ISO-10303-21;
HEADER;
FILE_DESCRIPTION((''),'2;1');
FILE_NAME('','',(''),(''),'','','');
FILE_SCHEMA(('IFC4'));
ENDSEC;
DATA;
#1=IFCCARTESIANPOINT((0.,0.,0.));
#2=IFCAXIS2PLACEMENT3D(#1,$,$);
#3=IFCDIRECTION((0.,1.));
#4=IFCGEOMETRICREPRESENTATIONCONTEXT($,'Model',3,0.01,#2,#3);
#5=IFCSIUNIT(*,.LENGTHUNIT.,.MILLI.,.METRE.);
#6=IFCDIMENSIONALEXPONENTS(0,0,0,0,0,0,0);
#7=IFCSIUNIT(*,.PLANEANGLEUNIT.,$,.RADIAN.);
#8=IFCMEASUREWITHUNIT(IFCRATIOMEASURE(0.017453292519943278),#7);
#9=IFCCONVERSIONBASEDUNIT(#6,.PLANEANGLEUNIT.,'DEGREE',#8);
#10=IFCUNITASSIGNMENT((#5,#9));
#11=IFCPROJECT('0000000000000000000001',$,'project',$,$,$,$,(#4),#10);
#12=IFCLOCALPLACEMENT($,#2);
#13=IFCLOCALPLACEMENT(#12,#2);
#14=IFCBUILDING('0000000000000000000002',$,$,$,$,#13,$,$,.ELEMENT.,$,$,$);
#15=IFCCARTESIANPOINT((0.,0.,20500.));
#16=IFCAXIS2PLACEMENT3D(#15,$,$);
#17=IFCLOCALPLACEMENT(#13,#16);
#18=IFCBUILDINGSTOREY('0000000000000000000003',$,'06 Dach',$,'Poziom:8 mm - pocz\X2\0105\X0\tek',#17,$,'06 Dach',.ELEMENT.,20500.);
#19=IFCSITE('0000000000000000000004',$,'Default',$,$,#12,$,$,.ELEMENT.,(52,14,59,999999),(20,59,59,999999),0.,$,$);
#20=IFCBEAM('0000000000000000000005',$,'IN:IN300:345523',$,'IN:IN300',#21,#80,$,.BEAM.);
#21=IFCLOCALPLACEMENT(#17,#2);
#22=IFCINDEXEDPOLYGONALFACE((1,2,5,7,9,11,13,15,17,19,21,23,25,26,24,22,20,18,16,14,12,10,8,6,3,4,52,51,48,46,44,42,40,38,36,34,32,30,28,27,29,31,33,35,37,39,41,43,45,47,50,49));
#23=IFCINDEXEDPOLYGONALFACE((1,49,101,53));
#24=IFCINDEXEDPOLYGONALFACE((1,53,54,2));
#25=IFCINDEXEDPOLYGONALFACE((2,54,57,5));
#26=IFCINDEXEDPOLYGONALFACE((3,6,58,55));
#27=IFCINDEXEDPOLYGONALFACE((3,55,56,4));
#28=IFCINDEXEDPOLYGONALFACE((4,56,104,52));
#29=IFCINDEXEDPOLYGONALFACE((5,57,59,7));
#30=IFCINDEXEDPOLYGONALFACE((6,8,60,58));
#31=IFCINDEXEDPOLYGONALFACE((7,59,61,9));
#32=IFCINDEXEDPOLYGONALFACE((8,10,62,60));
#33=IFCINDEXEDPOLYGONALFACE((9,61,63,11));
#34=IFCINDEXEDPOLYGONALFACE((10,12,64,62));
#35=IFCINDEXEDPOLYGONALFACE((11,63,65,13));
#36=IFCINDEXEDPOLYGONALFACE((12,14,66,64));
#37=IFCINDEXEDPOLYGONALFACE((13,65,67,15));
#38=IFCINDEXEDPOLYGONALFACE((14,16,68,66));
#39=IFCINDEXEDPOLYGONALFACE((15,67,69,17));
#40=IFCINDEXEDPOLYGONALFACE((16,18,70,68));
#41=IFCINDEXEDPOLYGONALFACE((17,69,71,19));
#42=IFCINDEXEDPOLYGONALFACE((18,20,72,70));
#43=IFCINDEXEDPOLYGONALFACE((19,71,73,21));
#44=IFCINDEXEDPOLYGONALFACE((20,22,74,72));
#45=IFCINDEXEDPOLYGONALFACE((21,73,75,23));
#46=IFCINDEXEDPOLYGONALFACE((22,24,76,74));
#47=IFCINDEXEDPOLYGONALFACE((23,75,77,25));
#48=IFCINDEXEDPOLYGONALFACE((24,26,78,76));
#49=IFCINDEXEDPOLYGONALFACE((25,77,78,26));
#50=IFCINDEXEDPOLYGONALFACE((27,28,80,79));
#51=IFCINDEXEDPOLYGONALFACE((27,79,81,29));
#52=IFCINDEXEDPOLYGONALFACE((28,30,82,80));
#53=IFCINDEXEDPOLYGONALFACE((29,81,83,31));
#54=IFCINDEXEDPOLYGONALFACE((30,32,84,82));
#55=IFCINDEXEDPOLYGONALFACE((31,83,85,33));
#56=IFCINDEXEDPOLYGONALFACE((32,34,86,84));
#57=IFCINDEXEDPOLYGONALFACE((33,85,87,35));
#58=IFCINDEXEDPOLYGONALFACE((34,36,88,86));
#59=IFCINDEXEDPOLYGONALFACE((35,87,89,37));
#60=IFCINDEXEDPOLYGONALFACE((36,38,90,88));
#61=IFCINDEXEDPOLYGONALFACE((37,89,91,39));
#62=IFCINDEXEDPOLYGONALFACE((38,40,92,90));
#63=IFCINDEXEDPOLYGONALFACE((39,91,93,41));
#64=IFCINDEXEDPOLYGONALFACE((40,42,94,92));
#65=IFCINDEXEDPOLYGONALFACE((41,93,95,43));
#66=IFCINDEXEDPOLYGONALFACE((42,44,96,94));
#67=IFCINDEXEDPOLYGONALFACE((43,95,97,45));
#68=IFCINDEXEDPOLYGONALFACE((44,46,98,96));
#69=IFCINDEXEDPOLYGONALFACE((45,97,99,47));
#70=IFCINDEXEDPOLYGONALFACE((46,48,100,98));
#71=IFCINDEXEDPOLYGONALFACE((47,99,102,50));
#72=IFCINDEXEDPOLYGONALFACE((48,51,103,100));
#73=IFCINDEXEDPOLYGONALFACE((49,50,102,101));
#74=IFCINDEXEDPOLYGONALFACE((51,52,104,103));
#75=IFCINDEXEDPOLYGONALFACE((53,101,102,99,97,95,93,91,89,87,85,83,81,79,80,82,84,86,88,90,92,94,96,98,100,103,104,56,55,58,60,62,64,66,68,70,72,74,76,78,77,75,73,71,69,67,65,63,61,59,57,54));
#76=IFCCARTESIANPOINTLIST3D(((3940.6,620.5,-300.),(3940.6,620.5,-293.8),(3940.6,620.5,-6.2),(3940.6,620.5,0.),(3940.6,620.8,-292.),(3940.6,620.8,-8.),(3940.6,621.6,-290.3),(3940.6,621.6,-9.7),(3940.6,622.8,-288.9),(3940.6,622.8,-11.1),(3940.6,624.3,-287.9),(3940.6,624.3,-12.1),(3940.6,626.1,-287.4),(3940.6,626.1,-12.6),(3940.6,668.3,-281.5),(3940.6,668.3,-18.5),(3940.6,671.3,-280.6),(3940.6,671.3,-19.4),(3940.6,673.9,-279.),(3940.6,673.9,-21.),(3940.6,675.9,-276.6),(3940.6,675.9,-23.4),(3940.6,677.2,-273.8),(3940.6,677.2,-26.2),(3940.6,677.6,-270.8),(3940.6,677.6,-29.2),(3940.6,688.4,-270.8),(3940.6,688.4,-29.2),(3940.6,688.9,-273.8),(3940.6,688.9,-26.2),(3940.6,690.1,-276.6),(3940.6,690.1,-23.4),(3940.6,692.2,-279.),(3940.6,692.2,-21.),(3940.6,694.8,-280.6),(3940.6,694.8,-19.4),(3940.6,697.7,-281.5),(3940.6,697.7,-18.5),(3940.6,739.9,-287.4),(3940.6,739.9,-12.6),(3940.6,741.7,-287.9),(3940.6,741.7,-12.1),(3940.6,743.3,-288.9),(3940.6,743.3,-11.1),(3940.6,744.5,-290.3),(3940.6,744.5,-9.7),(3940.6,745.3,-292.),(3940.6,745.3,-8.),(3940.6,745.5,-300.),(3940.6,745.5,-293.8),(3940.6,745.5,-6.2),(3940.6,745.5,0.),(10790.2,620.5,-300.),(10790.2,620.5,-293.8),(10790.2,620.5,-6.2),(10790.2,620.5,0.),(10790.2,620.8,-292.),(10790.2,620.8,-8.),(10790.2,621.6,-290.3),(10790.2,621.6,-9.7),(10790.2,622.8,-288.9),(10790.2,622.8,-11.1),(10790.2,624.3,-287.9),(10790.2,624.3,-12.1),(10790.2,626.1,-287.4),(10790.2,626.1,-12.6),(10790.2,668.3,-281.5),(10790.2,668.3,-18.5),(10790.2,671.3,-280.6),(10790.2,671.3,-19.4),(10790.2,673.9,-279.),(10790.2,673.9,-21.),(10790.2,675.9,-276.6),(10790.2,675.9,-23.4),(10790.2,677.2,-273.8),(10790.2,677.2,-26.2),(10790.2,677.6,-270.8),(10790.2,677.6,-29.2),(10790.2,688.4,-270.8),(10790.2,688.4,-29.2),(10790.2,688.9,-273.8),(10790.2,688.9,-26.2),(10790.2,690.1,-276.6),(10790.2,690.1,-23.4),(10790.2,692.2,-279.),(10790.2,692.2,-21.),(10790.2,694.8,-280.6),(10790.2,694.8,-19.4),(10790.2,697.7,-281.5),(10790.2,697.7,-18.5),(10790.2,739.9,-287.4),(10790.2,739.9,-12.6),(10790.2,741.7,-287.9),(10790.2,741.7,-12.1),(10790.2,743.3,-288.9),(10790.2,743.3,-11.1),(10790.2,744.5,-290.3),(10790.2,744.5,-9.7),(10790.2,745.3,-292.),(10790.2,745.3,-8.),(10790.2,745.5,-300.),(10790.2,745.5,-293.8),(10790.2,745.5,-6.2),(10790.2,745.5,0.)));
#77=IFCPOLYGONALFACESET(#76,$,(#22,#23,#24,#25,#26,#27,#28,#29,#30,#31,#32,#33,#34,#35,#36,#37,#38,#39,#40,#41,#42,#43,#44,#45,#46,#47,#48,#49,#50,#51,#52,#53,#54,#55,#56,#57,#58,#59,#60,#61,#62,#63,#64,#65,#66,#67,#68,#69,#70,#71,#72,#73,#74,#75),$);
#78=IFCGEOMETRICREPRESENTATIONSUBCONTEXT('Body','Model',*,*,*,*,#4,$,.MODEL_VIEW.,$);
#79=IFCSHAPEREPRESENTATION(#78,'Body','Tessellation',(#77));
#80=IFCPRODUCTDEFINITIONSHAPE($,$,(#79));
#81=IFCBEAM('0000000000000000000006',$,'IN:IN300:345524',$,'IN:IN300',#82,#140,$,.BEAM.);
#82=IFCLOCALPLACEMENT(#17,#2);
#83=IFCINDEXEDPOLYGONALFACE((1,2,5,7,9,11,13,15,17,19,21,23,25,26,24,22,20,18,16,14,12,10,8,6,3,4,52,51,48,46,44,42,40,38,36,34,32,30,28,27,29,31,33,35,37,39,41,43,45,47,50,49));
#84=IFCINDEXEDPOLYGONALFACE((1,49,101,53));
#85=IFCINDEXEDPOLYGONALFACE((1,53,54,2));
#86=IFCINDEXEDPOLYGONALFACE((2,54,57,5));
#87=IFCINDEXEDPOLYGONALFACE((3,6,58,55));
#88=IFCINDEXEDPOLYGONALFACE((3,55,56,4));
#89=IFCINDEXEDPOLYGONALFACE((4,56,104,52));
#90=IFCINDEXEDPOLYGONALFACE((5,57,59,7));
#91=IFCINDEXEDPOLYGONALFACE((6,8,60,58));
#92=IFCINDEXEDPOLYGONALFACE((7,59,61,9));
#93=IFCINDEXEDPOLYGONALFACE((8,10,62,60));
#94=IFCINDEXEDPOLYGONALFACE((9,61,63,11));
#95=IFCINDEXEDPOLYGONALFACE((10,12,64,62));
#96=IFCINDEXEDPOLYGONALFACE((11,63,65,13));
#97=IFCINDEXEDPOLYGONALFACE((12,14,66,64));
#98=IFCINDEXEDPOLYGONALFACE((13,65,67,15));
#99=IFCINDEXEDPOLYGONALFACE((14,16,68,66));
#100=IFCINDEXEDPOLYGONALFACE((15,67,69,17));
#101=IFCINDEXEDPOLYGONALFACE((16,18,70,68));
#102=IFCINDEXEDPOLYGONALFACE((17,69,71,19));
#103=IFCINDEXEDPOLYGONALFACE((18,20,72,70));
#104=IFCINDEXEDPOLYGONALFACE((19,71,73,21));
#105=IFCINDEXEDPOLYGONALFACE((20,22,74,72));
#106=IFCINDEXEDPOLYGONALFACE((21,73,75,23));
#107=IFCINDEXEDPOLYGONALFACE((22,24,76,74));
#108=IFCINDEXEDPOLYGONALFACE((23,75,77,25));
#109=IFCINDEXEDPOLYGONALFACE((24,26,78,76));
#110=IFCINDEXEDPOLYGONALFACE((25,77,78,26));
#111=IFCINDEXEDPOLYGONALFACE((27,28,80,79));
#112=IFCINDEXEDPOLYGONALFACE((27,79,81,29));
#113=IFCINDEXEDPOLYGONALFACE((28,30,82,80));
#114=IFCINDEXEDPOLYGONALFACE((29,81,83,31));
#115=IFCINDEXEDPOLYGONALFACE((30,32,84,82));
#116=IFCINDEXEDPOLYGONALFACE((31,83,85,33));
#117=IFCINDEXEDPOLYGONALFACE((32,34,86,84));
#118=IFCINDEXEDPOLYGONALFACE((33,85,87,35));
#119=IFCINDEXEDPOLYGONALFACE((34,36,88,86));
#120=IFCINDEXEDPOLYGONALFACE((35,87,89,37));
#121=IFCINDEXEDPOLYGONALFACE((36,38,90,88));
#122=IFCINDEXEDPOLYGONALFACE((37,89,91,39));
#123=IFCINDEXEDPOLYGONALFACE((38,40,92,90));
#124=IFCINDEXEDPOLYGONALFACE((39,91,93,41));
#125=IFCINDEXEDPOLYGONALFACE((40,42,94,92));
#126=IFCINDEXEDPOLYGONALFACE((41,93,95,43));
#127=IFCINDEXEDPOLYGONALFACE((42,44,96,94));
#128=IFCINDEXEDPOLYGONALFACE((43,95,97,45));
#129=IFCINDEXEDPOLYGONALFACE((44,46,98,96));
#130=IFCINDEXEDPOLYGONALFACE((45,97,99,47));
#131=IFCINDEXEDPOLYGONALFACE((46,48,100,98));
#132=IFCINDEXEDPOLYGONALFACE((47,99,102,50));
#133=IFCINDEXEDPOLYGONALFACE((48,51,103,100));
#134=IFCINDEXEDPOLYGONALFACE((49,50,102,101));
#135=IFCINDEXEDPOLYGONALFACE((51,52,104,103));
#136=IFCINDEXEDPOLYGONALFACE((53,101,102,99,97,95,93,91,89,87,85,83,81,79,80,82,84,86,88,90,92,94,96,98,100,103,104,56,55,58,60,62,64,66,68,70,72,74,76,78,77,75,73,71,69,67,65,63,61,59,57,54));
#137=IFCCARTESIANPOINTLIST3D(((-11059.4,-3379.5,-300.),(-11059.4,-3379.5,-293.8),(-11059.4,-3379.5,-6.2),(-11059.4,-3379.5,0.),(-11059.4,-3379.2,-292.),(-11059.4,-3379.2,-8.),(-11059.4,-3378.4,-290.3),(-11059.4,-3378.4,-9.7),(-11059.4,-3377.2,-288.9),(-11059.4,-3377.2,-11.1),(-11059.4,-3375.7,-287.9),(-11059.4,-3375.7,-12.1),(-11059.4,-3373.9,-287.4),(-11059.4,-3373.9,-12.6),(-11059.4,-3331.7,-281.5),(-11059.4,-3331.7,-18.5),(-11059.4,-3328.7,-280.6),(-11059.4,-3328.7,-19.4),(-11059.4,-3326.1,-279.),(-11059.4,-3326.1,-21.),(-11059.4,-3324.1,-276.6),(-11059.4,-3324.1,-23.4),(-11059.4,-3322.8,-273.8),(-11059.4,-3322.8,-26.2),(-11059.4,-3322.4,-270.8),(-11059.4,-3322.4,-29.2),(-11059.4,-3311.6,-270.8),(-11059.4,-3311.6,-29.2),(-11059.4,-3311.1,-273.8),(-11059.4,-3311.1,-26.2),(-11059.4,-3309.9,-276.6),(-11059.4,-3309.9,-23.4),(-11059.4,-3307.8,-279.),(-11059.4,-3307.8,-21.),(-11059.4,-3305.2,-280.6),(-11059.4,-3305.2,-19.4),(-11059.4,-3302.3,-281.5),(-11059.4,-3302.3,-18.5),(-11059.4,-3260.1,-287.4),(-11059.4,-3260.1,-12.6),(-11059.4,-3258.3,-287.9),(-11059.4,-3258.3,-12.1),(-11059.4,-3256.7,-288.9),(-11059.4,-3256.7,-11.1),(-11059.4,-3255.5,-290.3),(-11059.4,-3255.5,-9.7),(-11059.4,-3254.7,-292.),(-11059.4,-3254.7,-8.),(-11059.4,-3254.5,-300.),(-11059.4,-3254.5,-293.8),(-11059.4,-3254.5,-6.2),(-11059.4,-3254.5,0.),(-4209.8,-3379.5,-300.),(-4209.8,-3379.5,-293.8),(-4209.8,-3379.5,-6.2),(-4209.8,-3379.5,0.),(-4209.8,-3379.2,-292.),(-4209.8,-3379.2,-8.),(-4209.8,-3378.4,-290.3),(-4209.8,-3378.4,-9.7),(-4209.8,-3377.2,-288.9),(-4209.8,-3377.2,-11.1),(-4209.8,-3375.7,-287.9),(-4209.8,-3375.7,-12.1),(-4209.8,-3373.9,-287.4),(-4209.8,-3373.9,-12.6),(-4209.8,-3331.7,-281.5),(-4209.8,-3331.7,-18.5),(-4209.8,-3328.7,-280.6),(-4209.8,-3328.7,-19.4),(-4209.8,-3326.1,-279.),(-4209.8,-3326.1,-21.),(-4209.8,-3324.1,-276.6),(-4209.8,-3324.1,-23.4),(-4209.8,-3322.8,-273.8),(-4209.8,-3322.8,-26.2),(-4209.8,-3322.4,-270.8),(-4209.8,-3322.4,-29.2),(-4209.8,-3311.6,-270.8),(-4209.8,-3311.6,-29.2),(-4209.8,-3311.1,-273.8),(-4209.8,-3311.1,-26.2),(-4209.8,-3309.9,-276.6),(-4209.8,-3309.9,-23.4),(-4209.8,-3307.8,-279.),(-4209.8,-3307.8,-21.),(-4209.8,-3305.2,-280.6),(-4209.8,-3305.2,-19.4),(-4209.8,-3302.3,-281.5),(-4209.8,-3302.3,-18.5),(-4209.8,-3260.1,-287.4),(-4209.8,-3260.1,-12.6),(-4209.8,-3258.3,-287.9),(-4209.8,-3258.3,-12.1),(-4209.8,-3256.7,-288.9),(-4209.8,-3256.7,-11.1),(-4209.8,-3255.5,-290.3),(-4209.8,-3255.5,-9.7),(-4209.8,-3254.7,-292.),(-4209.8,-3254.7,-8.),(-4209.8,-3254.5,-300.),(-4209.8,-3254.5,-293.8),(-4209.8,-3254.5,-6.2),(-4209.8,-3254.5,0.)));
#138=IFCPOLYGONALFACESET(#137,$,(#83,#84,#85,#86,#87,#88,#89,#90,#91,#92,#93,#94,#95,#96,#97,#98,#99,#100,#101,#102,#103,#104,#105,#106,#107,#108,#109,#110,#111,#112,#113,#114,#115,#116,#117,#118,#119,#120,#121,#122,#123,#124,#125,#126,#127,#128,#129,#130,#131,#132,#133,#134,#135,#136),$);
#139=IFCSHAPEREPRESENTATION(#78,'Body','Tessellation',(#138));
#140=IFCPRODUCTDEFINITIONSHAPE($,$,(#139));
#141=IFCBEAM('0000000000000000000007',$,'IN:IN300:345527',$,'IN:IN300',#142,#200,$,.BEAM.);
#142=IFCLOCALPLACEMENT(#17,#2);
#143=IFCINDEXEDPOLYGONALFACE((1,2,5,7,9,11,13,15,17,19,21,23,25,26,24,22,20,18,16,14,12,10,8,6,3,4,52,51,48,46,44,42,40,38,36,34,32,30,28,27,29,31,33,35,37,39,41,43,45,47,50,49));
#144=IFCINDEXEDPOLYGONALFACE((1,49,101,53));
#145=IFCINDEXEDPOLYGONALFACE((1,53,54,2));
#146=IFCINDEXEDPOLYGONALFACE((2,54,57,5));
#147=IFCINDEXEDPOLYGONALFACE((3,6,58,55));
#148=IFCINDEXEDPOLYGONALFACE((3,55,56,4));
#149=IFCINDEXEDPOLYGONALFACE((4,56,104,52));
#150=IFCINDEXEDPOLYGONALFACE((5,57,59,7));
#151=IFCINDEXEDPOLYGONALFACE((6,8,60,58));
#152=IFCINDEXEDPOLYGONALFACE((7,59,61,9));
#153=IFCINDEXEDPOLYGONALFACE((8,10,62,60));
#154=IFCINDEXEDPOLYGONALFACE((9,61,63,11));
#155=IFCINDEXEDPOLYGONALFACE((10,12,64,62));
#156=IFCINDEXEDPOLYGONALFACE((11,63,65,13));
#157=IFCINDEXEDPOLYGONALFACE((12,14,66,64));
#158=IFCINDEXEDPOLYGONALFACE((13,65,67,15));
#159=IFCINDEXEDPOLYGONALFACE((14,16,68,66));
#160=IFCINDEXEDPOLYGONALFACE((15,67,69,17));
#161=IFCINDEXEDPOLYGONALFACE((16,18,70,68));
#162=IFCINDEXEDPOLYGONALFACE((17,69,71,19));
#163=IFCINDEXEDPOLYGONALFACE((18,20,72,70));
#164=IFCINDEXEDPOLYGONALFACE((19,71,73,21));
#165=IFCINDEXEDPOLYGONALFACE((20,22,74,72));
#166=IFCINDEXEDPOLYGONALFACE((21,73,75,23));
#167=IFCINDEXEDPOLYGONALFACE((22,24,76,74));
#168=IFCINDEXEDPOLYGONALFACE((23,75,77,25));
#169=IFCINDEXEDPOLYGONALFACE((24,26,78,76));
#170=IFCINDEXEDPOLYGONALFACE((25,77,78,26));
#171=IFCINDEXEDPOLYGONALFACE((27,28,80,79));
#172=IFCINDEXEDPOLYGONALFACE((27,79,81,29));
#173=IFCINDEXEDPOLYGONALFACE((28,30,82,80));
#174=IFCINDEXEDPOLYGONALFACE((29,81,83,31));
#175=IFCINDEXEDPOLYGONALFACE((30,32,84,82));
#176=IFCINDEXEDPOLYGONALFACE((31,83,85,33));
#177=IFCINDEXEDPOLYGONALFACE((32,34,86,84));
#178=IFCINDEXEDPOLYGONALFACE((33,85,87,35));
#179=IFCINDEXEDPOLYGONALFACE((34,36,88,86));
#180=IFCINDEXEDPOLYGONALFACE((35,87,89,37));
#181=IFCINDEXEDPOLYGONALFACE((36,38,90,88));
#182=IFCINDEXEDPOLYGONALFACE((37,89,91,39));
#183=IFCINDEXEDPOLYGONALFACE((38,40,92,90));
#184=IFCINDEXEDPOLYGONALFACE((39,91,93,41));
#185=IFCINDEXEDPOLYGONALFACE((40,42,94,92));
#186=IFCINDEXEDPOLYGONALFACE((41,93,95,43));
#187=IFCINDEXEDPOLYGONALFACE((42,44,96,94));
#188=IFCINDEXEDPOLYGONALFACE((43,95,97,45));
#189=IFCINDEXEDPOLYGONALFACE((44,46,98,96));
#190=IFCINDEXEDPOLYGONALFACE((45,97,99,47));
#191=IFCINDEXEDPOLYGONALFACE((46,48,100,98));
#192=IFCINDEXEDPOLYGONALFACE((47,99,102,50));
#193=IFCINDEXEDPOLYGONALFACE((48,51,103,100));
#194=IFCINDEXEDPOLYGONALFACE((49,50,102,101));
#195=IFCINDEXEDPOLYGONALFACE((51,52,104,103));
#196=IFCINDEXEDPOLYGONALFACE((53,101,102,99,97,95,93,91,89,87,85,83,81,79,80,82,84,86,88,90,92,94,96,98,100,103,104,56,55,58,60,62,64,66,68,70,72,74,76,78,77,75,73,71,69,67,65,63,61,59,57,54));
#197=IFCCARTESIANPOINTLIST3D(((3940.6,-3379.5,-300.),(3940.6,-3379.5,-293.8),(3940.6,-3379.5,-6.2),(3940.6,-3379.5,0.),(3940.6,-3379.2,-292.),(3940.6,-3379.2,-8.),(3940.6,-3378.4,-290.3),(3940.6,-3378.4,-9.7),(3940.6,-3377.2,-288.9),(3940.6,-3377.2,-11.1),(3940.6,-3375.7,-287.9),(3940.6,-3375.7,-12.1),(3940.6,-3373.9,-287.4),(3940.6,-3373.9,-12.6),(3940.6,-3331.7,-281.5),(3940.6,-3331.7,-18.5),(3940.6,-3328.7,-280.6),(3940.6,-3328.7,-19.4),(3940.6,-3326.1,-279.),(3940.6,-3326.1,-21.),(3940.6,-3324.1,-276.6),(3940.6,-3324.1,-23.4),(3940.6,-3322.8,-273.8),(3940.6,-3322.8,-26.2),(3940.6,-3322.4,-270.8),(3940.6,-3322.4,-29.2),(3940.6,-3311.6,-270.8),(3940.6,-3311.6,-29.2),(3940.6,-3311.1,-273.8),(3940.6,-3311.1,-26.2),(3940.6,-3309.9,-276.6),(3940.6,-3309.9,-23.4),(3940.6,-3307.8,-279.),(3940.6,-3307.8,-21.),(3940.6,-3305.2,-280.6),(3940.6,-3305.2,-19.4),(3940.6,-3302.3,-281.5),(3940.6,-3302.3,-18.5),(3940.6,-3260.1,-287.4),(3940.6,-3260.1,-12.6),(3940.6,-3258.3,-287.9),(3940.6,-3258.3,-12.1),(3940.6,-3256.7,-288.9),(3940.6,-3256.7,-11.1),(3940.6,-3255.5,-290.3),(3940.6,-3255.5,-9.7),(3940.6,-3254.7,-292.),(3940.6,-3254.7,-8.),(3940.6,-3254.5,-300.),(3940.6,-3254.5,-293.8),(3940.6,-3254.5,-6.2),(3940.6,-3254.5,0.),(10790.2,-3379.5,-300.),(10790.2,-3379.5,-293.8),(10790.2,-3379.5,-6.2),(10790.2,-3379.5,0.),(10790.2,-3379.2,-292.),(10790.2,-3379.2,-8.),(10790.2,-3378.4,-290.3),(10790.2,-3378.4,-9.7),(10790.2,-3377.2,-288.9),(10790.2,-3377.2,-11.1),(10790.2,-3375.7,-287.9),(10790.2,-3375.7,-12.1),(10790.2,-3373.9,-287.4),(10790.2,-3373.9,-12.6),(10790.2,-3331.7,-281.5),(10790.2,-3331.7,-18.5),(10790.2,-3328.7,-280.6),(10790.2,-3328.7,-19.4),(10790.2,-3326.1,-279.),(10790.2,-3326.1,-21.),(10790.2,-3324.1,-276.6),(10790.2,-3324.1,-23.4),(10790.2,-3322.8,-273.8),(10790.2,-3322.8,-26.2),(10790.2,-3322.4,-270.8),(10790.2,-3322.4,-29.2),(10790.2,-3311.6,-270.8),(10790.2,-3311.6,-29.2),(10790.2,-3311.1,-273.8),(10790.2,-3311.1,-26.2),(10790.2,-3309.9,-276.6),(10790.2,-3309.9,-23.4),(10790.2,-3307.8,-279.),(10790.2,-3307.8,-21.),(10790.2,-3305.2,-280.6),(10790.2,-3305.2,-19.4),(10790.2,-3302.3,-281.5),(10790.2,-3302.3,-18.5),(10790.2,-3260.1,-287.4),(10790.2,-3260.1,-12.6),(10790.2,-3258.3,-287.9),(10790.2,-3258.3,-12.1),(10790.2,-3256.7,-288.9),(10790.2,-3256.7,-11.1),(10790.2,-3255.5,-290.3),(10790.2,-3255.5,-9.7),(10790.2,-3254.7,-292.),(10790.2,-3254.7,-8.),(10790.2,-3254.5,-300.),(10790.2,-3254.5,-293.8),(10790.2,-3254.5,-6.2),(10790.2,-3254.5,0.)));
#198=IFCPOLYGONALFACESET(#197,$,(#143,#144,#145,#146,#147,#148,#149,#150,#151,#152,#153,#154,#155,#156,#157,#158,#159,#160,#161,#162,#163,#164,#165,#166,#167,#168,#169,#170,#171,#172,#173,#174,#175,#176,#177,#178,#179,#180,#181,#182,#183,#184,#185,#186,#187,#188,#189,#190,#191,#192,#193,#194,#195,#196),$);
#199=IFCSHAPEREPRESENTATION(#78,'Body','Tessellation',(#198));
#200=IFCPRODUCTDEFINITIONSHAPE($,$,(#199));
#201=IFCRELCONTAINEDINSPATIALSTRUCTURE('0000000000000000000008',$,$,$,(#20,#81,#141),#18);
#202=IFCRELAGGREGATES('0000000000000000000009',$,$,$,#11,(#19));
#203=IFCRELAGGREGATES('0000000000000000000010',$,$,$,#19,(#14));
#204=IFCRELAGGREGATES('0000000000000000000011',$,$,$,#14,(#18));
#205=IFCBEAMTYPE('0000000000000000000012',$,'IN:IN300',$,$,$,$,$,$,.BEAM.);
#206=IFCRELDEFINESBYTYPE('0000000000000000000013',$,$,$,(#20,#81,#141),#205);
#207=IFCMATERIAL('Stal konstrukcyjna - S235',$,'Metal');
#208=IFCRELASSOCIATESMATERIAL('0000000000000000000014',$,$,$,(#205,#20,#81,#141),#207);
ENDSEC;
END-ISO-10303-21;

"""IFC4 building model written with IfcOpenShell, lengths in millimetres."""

from ifc_helpers import new_model, entity, si_unit, converted_unit, direction, frame, origin, place, context, subcontext, project, spatial, line, arc, indexed_curve, outline, extrude, source, transform, mapped, material, type_object, type_shapes, element, save


model = new_model("IFC4")

# Units and contexts
model_context = context("Model", 3, precision=0.01, world=origin(), true_north=direction((0.0, 1.0)))
body_context = subcontext(model_context, "Body", "Model", "MODEL_VIEW")
ifc_project = project(units=[si_unit("LENGTHUNIT", "METRE", prefix="MILLI"), converted_unit("PLANEANGLEUNIT", "DEGREE", entity("IfcRatioMeasure", 0.017453292519943278), si_unit("PLANEANGLEUNIT", "RADIAN"), dimensions=[0, 0, 0, 0, 0, 0, 0])], contexts=[model_context])

# Site, building, storey
site_placement = place(None, origin())
site = spatial("IfcSite", under=ifc_project, at=site_placement, Name="Default", CompositionType="ELEMENT", RefLatitude=(52, 14, 59, 999999), RefLongitude=(20, 59, 59, 999999), RefElevation=0.0)
building_placement = place(site_placement, origin())
building = spatial("IfcBuilding", under=site, at=building_placement, CompositionType="ELEMENT")
storey_placement = place(building_placement, frame((0.0, 0.0, 20500.0)))
storey = spatial("IfcBuildingStorey", under=building, at=storey_placement, Name="06 Dach", ObjectType="Poziom:8 mm - początek", LongName="06 Dach", CompositionType="ELEMENT", Elevation=20500.0)

# Beams
ifc_material_1 = material(Name="Stal konstrukcyjna - S235", Category="Metal")
beam_type_1 = type_object("IfcBeamType", Name="IN:IN300", PredefinedType="BEAM", material=ifc_material_1)
shared_shape_1 = source(origin(), body_context, "Body", "SweptSolid", [
    extrude(outline(indexed_curve([(143.8, -62.5), (150.0, -62.5), (150.0, 62.5), (143.8, 62.5), (139.6, 60.9), (137.4, 56.9), (131.5, 14.7), (127.9, 8.1), (120.8, 5.4), (-120.8, 5.4), (-127.9, 8.1), (-131.5, 14.7), (-137.4, 56.9), (-139.6, 60.9), (-143.8, 62.5), (-150.0, 62.5), (-150.0, -62.5), (-143.8, -62.5), (-139.6, -60.9), (-137.4, -56.9), (-131.5, -14.7), (-127.9, -8.1), (-120.8, -5.4), (120.8, -5.4), (127.9, -8.1), (131.5, -14.7), (137.4, -56.9), (139.6, -60.9)], segments=[line(1, 2, 3, 4), arc(4, 5, 6), line(6, 7), arc(7, 8, 9), line(9, 10), arc(10, 11, 12), line(12, 13), arc(13, 14, 15), line(15, 16, 17, 18), arc(18, 19, 20), line(20, 21), arc(21, 22, 23), line(23, 24), arc(24, 25, 26), line(26, 27), arc(27, 28, 1)], self_intersect=False)), frame((-3424.8, 0.0, 0.0), z_axis=(1.0, 0.0, 0.0), x_axis=(0.0, 0.0, -1.0)), (0.0, 0.0, 1.0), 6849.6),
])
type_shapes(beam_type_1, [shared_shape_1])
for number, where, name in (
    (1, (7365.4, 683.0, -150.0), "IN:IN300:345523"),
    (2, (-7634.6, -3317.0, -150.0), "IN:IN300:345524"),
    (3, (7365.4, -3317.0, -150.0), "IN:IN300:345527"),
):
    element("IfcBeam", number, at=place(storey_placement, frame(where)), inside=storey, type_object=beam_type_1, material=ifc_material_1, Name=name, ObjectType="IN:IN300", PredefinedType="BEAM", context=body_context, shape_type="MappedRepresentation", body=[
        mapped(shared_shape_1, transform((0.0, 0.0, 0.0), scale=1.0)),
    ])

save(model, "model.ifc")
